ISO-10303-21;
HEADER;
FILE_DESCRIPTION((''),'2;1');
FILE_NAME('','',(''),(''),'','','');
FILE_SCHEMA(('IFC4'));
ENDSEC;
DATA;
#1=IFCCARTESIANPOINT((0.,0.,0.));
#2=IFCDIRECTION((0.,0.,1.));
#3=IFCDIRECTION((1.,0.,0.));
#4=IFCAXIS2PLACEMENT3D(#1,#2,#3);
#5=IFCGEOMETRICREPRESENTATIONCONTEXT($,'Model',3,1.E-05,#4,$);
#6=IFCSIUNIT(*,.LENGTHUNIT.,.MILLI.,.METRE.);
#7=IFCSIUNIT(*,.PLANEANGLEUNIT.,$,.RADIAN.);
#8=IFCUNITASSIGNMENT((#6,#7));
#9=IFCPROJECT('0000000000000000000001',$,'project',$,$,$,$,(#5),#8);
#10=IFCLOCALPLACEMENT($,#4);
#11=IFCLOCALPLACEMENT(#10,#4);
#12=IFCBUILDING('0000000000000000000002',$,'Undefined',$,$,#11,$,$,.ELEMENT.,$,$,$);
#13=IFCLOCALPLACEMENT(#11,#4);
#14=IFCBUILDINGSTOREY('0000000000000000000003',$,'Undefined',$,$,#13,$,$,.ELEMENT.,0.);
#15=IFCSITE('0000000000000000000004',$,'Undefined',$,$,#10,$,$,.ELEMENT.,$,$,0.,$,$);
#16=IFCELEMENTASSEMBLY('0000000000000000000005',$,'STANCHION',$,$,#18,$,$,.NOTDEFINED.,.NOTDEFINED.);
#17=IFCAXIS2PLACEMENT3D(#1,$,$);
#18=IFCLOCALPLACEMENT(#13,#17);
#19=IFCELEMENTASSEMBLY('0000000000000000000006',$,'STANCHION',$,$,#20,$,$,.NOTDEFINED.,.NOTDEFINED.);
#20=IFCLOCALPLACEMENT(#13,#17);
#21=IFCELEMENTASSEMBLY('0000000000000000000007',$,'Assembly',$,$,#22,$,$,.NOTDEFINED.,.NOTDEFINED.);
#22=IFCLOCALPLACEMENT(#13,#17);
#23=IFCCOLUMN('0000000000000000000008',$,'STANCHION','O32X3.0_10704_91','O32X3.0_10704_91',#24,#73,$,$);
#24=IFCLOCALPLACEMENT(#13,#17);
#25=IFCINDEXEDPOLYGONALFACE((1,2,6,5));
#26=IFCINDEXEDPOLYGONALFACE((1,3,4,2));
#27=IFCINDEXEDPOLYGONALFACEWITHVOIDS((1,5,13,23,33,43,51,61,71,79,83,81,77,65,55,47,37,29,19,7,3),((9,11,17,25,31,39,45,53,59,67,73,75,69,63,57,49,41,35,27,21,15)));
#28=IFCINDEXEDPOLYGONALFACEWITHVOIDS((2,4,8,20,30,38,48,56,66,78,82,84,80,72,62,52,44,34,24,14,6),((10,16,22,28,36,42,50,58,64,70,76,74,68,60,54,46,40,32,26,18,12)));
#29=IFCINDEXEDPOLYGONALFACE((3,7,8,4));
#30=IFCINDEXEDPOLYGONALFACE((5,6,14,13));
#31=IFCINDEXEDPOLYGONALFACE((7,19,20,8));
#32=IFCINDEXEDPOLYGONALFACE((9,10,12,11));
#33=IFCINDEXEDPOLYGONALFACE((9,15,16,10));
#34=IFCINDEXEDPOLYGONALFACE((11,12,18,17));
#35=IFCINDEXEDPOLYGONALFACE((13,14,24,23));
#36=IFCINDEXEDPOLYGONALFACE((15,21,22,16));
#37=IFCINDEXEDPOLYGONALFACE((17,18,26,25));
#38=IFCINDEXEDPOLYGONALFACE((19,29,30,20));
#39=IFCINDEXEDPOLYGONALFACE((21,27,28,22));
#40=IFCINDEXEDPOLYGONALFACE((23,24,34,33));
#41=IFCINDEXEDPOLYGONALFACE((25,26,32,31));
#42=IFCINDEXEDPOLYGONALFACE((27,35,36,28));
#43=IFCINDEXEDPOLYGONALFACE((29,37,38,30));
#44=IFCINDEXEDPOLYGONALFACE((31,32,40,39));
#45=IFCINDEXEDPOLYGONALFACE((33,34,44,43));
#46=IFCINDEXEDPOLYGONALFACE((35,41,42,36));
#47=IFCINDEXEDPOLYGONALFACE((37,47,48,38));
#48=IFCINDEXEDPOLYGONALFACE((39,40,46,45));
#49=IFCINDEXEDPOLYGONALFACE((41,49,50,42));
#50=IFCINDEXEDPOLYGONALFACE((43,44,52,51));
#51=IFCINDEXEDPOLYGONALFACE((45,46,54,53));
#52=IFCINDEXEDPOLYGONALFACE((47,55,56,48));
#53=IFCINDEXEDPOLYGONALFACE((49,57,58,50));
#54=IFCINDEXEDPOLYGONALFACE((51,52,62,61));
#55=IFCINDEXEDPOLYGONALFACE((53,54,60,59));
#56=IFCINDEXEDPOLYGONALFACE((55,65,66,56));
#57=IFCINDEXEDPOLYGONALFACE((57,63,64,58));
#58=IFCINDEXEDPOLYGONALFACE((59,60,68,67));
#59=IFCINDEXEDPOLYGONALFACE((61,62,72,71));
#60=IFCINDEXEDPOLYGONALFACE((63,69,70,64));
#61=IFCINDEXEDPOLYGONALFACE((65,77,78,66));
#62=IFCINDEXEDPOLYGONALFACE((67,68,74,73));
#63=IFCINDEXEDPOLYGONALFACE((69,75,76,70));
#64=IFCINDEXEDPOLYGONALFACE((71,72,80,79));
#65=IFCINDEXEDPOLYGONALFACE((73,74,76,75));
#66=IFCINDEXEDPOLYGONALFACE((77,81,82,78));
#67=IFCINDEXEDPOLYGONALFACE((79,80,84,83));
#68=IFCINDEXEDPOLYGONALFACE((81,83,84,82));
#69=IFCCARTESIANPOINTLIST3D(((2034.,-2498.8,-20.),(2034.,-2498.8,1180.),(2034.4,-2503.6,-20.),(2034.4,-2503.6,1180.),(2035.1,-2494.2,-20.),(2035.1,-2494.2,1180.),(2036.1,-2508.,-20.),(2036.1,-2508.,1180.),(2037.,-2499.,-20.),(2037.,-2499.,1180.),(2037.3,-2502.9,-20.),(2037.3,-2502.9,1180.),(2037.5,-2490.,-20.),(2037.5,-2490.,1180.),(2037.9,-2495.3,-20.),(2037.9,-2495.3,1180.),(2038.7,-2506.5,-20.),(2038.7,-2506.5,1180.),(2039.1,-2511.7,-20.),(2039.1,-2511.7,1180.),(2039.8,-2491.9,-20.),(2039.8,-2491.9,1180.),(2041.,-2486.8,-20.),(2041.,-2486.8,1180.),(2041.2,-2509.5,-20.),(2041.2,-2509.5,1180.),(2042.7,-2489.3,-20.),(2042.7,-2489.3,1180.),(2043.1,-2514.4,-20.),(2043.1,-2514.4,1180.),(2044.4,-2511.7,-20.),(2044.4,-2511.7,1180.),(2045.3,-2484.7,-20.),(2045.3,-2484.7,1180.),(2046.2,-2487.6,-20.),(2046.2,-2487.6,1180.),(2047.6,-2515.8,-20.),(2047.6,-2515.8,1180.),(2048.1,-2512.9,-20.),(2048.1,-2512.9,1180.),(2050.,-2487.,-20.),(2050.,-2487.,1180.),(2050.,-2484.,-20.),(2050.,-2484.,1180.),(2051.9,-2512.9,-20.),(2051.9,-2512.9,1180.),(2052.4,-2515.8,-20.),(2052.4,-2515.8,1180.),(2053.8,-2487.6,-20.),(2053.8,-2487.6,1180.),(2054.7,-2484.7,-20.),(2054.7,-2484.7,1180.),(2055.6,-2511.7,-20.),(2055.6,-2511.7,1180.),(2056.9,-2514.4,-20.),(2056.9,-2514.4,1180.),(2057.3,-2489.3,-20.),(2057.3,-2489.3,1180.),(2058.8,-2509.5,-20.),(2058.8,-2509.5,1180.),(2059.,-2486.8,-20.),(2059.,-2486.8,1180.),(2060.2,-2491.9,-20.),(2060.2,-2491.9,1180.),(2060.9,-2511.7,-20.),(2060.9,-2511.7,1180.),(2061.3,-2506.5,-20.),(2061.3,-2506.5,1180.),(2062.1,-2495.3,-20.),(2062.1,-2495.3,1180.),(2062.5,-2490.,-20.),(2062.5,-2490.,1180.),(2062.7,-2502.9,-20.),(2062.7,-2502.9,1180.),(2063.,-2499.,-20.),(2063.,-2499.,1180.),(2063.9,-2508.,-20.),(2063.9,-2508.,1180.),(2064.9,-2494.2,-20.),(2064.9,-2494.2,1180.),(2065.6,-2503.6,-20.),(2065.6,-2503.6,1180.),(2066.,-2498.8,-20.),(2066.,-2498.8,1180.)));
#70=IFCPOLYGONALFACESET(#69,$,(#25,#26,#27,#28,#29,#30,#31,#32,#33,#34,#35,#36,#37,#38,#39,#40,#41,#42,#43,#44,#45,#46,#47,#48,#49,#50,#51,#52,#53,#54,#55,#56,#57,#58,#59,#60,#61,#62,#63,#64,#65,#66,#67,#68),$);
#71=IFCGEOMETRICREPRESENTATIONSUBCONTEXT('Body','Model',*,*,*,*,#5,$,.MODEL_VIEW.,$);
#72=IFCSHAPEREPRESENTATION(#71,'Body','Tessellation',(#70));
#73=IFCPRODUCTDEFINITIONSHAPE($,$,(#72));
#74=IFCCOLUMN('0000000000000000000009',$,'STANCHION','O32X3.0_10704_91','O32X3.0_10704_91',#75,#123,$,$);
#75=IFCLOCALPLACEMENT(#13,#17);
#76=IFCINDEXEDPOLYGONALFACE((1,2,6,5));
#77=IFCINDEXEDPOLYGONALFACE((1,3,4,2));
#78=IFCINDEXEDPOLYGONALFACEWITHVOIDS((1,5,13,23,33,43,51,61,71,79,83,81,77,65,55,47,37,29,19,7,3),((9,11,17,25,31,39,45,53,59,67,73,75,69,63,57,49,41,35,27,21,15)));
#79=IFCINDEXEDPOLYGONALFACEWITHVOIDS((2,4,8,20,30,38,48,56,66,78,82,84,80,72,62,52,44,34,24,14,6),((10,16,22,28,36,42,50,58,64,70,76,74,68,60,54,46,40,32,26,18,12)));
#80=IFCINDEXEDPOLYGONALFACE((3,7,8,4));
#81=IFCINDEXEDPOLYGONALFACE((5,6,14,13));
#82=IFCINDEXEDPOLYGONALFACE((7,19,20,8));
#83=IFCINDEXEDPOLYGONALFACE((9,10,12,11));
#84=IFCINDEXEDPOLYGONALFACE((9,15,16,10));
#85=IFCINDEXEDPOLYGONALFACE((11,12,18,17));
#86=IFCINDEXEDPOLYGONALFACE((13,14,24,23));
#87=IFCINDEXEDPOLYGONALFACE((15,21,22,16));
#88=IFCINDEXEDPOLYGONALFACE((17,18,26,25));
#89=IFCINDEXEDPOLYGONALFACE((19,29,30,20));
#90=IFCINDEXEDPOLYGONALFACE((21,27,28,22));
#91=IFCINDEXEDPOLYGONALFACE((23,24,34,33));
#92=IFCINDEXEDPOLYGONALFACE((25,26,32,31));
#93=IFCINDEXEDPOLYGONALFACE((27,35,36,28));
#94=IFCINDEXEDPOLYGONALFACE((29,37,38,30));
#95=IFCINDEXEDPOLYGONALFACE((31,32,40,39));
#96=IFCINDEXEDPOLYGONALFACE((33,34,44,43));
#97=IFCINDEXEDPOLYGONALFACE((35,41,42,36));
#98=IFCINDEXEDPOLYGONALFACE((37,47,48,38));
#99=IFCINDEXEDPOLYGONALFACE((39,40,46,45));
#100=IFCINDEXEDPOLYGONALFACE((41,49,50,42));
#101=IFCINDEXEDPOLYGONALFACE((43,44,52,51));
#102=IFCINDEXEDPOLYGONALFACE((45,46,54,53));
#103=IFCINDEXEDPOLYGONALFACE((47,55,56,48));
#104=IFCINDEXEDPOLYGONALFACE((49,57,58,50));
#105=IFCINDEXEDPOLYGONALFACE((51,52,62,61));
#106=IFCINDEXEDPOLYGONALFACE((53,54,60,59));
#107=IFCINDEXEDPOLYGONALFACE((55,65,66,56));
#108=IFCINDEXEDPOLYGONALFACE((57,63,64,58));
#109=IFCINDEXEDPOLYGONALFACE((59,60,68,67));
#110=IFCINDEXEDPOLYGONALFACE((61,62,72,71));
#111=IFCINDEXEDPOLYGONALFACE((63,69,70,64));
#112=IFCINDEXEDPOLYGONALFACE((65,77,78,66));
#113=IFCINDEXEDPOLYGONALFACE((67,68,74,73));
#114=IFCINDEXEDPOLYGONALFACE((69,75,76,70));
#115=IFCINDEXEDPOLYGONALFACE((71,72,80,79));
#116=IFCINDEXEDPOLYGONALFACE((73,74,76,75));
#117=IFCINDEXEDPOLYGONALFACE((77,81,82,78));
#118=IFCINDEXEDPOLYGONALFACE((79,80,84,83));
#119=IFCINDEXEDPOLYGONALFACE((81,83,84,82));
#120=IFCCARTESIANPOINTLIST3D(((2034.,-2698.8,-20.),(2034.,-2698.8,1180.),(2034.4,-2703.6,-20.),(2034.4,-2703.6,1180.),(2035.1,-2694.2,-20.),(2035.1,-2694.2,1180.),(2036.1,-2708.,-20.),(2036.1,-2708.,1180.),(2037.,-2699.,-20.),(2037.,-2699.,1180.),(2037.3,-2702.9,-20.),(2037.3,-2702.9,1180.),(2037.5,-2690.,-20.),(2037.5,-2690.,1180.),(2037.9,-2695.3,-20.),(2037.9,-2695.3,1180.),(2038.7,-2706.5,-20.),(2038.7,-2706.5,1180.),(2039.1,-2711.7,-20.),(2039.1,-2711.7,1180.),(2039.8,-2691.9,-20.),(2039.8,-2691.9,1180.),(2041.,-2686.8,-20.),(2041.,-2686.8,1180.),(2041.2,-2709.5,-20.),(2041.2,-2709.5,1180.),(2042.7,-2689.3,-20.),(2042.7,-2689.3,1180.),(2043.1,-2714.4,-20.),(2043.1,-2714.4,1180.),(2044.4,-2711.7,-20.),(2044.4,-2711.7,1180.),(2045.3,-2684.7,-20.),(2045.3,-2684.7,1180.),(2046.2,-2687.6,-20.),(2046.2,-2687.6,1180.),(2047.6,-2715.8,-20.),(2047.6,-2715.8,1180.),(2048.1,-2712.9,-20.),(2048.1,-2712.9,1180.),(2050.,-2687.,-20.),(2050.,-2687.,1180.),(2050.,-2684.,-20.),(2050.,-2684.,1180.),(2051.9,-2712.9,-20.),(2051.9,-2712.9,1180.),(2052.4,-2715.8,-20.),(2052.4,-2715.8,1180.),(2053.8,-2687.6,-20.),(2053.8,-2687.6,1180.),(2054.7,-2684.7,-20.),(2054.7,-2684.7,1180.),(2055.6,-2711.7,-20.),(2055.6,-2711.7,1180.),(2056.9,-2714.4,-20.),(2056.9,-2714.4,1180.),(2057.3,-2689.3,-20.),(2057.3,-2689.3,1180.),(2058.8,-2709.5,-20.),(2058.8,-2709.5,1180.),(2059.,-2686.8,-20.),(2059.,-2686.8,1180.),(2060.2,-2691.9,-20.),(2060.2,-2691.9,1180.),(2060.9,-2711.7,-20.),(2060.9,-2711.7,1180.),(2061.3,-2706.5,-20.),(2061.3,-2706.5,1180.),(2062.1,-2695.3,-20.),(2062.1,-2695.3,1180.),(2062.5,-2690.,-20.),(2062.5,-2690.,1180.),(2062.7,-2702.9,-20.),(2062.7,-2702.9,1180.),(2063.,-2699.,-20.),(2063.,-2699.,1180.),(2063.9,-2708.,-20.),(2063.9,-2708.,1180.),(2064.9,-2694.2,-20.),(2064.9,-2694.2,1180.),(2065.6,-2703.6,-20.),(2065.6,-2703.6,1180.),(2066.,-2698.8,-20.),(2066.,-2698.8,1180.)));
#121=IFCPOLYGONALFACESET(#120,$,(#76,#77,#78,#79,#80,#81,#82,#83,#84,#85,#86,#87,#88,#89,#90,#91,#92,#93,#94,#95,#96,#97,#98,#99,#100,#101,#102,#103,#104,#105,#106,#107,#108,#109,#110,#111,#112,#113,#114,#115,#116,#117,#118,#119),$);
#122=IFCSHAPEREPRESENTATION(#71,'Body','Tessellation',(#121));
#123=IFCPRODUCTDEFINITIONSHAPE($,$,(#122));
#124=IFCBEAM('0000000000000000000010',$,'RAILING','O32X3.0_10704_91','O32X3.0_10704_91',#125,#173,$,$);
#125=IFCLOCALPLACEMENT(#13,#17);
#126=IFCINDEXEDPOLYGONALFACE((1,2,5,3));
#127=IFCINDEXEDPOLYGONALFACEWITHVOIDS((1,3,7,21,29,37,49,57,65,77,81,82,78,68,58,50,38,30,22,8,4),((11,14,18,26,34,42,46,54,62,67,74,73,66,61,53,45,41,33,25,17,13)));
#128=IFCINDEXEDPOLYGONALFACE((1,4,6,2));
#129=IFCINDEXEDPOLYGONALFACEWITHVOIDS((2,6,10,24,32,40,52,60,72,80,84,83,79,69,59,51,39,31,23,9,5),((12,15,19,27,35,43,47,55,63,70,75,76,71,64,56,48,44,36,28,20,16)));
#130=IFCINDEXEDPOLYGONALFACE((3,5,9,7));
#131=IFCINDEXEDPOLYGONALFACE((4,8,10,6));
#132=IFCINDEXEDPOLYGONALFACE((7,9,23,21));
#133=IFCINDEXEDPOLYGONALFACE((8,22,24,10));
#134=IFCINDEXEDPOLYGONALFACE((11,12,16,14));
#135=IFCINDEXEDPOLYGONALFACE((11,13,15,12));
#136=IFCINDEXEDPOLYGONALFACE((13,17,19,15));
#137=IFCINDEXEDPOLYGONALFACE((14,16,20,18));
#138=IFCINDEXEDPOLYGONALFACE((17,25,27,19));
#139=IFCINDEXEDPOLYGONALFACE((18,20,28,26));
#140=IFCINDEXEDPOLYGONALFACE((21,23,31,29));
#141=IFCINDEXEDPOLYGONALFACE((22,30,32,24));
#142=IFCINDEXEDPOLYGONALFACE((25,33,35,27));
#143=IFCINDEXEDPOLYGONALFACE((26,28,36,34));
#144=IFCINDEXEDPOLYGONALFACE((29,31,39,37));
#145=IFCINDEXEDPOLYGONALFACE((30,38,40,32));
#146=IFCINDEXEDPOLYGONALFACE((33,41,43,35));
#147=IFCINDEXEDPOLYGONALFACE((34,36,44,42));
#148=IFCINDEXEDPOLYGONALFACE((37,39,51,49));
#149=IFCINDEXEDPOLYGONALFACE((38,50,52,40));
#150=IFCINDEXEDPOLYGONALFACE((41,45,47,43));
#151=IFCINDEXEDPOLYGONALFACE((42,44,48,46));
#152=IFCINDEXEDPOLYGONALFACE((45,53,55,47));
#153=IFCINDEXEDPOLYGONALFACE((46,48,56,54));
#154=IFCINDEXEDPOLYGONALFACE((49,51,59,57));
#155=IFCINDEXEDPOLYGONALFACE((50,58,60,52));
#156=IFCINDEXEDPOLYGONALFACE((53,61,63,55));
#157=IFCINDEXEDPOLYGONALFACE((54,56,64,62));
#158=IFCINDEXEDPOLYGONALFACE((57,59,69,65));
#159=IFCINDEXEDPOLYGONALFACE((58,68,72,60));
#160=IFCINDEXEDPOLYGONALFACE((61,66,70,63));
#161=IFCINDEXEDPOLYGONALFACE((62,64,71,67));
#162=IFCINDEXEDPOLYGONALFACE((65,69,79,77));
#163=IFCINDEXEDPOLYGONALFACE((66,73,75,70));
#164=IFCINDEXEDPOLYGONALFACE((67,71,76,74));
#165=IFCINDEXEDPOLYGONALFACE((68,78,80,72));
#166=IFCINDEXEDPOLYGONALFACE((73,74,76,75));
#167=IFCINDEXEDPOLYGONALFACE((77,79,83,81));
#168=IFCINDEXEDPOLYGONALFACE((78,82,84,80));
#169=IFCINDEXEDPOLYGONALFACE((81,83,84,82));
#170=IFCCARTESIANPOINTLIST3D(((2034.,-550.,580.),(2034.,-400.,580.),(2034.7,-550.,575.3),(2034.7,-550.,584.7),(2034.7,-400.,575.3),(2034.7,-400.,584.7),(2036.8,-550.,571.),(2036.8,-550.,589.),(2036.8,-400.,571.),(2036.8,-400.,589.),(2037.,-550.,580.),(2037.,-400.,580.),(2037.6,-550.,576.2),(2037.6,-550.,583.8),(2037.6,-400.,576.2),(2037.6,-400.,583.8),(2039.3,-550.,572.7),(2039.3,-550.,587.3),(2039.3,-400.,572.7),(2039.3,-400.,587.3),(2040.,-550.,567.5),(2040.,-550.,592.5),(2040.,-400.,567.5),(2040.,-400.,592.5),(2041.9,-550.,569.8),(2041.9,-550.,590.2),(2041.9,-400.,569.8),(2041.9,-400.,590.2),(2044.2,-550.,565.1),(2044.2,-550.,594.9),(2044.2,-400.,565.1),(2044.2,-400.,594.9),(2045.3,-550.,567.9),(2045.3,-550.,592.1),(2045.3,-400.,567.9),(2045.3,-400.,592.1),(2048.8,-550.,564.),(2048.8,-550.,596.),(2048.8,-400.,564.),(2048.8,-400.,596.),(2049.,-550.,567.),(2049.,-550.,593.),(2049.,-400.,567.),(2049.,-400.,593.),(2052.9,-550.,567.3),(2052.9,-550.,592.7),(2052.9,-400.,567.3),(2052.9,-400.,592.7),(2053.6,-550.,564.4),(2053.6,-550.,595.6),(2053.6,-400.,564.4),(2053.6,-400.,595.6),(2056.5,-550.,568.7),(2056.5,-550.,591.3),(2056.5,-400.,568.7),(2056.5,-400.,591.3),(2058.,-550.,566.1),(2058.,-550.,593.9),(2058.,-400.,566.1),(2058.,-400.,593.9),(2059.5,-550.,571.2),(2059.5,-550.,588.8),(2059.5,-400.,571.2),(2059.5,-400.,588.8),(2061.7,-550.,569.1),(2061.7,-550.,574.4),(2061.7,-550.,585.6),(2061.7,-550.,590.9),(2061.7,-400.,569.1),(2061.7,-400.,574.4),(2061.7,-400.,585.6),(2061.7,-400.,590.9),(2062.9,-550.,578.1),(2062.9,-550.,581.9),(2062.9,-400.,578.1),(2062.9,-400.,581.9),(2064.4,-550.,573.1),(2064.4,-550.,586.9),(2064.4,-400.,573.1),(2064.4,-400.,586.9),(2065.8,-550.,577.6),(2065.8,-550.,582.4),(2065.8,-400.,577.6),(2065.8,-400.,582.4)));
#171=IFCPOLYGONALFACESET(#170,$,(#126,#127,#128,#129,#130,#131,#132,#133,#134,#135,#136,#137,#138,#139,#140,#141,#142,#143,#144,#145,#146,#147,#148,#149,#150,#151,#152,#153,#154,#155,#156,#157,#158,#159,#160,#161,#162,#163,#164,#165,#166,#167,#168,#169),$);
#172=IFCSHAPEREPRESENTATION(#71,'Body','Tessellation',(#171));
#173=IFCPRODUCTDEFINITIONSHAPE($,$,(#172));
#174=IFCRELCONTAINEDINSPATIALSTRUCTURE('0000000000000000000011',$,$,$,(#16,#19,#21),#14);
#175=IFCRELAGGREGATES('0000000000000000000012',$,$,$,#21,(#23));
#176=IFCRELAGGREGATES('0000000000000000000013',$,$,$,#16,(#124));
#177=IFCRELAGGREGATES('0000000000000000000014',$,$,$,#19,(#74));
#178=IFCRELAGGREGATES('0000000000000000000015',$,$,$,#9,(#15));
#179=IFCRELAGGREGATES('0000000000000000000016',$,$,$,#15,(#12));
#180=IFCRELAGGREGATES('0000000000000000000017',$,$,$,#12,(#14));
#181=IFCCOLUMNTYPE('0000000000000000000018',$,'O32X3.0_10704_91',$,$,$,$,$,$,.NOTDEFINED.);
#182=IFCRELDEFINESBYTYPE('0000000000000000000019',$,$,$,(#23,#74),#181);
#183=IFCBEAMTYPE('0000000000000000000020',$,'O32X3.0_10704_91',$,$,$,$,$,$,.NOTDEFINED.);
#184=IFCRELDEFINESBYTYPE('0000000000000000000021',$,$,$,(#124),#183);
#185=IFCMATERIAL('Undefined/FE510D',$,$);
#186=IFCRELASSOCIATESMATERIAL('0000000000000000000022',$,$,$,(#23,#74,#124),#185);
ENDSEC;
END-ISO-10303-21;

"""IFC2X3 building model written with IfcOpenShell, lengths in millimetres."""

from ifc_helpers import new_model, si_unit, frame, origin_with_axes, origin_2d_with_axis, place, context, subcontext, project, spatial, hollow_circle, extrude, material, type_object, element, aggregate, save


model = new_model("IFC2X3")

# Units and contexts
model_context = context("Model", 3, precision=1e-05, world=origin_with_axes())
body_context = subcontext(model_context, "Body", "Model", "MODEL_VIEW")
ifc_project = project(units=[si_unit("LENGTHUNIT", "METRE", prefix="MILLI"), si_unit("PLANEANGLEUNIT", "RADIAN")], contexts=[model_context])

# Site, building, storey
site_placement = place(None, origin_with_axes())
site = spatial("IfcSite", under=ifc_project, at=site_placement, Name="Undefined", CompositionType="ELEMENT", RefElevation=0.0)
building_placement = place(site_placement, origin_with_axes())
building = spatial("IfcBuilding", under=site, at=building_placement, Name="Undefined", CompositionType="ELEMENT")
storey_placement = place(building_placement, origin_with_axes())
storey = spatial("IfcBuildingStorey", under=building, at=storey_placement, Name="Undefined", CompositionType="ELEMENT", Elevation=0.0)

# Element assembly
assembly_1_placement = place(storey_placement, origin_with_axes())
assembly_1 = element("IfcElementAssembly", 1, at=assembly_1_placement, inside=storey, Name="STANCHION", AssemblyPlace="NOTDEFINED", PredefinedType="NOTDEFINED")
column_type = type_object("IfcColumnType", Name="O32X3.0_10704_91", PredefinedType="NOTDEFINED")

# Shared definitions
ifc_material_1 = material(Name="Undefined/FE510D")

# Element assembly
assembly_2_placement = place(storey_placement, origin_with_axes())
assembly_2 = element("IfcElementAssembly", 2, at=assembly_2_placement, inside=storey, Name="STANCHION", AssemblyPlace="NOTDEFINED", PredefinedType="NOTDEFINED")

# Element assembly, column
assembly_3_placement = place(storey_placement, origin_with_axes())
assembly_3 = element("IfcElementAssembly", 3, at=assembly_3_placement, inside=storey, Name="Assembly", AssemblyPlace="NOTDEFINED", PredefinedType="NOTDEFINED")
column_1_placement = place(assembly_3_placement, frame((2050.0, -2500.0, -20.0), z_axis=(0.0, 0.0, 1.0), x_axis=(1.0, 0.0, 0.0)))
column_1 = element("IfcColumn", 4, at=column_1_placement, type_object=column_type, material=ifc_material_1, Name="STANCHION", Description="O32X3.0_10704_91", ObjectType="O32X3.0_10704_91", context=body_context, shape_type="SweptSolid", body=[
    extrude(hollow_circle(Radius=16.0, WallThickness=3.0, at=origin_2d_with_axis()), frame((0.0, 0.0, 1200.0), z_axis=(0.0, 0.0, -1.0), x_axis=(0.0, 1.0, 0.0)), (0.0, 0.0, 1.0), 1200.0),
])
aggregate(assembly_3, [column_1])

# Column
column_2_placement = place(assembly_2_placement, frame((2050.0, -2700.0, -20.0), z_axis=(0.0, 0.0, 1.0), x_axis=(1.0, 0.0, 0.0)))
column_2 = element("IfcColumn", 5, at=column_2_placement, type_object=column_type, material=ifc_material_1, Name="STANCHION", Description="O32X3.0_10704_91", ObjectType="O32X3.0_10704_91", context=body_context, shape_type="SweptSolid", body=[
    extrude(hollow_circle(Radius=16.0, WallThickness=3.0, at=origin_2d_with_axis()), frame((0.0, 0.0, 1200.0), z_axis=(0.0, 0.0, -1.0), x_axis=(0.0, 1.0, 0.0)), (0.0, 0.0, 1.0), 1200.0),
])

# Beam
beam_type_1 = type_object("IfcBeamType", Name="O32X3.0_10704_91", PredefinedType="NOTDEFINED")
beam_1_placement = place(assembly_1_placement, frame((2050.0, -550.0, 580.0), z_axis=(0.0, 0.0, -1.0), x_axis=(0.0, 1.0, 0.0)))
beam_1 = element("IfcBeam", 6, at=beam_1_placement, type_object=beam_type_1, material=ifc_material_1, Name="RAILING", Description="O32X3.0_10704_91", ObjectType="O32X3.0_10704_91", context=body_context, shape_type="SweptSolid", body=[
    extrude(hollow_circle(Radius=16.0, WallThickness=3.0, at=origin_2d_with_axis()), frame((150.0, 0.0, 0.0), z_axis=(-1.0, 0.0, 0.0), x_axis=(0.0, -1.0, 0.0)), (0.0, 0.0, 1.0), 150.0),
])
aggregate(assembly_1, [beam_1])
aggregate(assembly_2, [column_2])

save(model, "model.ifc")
